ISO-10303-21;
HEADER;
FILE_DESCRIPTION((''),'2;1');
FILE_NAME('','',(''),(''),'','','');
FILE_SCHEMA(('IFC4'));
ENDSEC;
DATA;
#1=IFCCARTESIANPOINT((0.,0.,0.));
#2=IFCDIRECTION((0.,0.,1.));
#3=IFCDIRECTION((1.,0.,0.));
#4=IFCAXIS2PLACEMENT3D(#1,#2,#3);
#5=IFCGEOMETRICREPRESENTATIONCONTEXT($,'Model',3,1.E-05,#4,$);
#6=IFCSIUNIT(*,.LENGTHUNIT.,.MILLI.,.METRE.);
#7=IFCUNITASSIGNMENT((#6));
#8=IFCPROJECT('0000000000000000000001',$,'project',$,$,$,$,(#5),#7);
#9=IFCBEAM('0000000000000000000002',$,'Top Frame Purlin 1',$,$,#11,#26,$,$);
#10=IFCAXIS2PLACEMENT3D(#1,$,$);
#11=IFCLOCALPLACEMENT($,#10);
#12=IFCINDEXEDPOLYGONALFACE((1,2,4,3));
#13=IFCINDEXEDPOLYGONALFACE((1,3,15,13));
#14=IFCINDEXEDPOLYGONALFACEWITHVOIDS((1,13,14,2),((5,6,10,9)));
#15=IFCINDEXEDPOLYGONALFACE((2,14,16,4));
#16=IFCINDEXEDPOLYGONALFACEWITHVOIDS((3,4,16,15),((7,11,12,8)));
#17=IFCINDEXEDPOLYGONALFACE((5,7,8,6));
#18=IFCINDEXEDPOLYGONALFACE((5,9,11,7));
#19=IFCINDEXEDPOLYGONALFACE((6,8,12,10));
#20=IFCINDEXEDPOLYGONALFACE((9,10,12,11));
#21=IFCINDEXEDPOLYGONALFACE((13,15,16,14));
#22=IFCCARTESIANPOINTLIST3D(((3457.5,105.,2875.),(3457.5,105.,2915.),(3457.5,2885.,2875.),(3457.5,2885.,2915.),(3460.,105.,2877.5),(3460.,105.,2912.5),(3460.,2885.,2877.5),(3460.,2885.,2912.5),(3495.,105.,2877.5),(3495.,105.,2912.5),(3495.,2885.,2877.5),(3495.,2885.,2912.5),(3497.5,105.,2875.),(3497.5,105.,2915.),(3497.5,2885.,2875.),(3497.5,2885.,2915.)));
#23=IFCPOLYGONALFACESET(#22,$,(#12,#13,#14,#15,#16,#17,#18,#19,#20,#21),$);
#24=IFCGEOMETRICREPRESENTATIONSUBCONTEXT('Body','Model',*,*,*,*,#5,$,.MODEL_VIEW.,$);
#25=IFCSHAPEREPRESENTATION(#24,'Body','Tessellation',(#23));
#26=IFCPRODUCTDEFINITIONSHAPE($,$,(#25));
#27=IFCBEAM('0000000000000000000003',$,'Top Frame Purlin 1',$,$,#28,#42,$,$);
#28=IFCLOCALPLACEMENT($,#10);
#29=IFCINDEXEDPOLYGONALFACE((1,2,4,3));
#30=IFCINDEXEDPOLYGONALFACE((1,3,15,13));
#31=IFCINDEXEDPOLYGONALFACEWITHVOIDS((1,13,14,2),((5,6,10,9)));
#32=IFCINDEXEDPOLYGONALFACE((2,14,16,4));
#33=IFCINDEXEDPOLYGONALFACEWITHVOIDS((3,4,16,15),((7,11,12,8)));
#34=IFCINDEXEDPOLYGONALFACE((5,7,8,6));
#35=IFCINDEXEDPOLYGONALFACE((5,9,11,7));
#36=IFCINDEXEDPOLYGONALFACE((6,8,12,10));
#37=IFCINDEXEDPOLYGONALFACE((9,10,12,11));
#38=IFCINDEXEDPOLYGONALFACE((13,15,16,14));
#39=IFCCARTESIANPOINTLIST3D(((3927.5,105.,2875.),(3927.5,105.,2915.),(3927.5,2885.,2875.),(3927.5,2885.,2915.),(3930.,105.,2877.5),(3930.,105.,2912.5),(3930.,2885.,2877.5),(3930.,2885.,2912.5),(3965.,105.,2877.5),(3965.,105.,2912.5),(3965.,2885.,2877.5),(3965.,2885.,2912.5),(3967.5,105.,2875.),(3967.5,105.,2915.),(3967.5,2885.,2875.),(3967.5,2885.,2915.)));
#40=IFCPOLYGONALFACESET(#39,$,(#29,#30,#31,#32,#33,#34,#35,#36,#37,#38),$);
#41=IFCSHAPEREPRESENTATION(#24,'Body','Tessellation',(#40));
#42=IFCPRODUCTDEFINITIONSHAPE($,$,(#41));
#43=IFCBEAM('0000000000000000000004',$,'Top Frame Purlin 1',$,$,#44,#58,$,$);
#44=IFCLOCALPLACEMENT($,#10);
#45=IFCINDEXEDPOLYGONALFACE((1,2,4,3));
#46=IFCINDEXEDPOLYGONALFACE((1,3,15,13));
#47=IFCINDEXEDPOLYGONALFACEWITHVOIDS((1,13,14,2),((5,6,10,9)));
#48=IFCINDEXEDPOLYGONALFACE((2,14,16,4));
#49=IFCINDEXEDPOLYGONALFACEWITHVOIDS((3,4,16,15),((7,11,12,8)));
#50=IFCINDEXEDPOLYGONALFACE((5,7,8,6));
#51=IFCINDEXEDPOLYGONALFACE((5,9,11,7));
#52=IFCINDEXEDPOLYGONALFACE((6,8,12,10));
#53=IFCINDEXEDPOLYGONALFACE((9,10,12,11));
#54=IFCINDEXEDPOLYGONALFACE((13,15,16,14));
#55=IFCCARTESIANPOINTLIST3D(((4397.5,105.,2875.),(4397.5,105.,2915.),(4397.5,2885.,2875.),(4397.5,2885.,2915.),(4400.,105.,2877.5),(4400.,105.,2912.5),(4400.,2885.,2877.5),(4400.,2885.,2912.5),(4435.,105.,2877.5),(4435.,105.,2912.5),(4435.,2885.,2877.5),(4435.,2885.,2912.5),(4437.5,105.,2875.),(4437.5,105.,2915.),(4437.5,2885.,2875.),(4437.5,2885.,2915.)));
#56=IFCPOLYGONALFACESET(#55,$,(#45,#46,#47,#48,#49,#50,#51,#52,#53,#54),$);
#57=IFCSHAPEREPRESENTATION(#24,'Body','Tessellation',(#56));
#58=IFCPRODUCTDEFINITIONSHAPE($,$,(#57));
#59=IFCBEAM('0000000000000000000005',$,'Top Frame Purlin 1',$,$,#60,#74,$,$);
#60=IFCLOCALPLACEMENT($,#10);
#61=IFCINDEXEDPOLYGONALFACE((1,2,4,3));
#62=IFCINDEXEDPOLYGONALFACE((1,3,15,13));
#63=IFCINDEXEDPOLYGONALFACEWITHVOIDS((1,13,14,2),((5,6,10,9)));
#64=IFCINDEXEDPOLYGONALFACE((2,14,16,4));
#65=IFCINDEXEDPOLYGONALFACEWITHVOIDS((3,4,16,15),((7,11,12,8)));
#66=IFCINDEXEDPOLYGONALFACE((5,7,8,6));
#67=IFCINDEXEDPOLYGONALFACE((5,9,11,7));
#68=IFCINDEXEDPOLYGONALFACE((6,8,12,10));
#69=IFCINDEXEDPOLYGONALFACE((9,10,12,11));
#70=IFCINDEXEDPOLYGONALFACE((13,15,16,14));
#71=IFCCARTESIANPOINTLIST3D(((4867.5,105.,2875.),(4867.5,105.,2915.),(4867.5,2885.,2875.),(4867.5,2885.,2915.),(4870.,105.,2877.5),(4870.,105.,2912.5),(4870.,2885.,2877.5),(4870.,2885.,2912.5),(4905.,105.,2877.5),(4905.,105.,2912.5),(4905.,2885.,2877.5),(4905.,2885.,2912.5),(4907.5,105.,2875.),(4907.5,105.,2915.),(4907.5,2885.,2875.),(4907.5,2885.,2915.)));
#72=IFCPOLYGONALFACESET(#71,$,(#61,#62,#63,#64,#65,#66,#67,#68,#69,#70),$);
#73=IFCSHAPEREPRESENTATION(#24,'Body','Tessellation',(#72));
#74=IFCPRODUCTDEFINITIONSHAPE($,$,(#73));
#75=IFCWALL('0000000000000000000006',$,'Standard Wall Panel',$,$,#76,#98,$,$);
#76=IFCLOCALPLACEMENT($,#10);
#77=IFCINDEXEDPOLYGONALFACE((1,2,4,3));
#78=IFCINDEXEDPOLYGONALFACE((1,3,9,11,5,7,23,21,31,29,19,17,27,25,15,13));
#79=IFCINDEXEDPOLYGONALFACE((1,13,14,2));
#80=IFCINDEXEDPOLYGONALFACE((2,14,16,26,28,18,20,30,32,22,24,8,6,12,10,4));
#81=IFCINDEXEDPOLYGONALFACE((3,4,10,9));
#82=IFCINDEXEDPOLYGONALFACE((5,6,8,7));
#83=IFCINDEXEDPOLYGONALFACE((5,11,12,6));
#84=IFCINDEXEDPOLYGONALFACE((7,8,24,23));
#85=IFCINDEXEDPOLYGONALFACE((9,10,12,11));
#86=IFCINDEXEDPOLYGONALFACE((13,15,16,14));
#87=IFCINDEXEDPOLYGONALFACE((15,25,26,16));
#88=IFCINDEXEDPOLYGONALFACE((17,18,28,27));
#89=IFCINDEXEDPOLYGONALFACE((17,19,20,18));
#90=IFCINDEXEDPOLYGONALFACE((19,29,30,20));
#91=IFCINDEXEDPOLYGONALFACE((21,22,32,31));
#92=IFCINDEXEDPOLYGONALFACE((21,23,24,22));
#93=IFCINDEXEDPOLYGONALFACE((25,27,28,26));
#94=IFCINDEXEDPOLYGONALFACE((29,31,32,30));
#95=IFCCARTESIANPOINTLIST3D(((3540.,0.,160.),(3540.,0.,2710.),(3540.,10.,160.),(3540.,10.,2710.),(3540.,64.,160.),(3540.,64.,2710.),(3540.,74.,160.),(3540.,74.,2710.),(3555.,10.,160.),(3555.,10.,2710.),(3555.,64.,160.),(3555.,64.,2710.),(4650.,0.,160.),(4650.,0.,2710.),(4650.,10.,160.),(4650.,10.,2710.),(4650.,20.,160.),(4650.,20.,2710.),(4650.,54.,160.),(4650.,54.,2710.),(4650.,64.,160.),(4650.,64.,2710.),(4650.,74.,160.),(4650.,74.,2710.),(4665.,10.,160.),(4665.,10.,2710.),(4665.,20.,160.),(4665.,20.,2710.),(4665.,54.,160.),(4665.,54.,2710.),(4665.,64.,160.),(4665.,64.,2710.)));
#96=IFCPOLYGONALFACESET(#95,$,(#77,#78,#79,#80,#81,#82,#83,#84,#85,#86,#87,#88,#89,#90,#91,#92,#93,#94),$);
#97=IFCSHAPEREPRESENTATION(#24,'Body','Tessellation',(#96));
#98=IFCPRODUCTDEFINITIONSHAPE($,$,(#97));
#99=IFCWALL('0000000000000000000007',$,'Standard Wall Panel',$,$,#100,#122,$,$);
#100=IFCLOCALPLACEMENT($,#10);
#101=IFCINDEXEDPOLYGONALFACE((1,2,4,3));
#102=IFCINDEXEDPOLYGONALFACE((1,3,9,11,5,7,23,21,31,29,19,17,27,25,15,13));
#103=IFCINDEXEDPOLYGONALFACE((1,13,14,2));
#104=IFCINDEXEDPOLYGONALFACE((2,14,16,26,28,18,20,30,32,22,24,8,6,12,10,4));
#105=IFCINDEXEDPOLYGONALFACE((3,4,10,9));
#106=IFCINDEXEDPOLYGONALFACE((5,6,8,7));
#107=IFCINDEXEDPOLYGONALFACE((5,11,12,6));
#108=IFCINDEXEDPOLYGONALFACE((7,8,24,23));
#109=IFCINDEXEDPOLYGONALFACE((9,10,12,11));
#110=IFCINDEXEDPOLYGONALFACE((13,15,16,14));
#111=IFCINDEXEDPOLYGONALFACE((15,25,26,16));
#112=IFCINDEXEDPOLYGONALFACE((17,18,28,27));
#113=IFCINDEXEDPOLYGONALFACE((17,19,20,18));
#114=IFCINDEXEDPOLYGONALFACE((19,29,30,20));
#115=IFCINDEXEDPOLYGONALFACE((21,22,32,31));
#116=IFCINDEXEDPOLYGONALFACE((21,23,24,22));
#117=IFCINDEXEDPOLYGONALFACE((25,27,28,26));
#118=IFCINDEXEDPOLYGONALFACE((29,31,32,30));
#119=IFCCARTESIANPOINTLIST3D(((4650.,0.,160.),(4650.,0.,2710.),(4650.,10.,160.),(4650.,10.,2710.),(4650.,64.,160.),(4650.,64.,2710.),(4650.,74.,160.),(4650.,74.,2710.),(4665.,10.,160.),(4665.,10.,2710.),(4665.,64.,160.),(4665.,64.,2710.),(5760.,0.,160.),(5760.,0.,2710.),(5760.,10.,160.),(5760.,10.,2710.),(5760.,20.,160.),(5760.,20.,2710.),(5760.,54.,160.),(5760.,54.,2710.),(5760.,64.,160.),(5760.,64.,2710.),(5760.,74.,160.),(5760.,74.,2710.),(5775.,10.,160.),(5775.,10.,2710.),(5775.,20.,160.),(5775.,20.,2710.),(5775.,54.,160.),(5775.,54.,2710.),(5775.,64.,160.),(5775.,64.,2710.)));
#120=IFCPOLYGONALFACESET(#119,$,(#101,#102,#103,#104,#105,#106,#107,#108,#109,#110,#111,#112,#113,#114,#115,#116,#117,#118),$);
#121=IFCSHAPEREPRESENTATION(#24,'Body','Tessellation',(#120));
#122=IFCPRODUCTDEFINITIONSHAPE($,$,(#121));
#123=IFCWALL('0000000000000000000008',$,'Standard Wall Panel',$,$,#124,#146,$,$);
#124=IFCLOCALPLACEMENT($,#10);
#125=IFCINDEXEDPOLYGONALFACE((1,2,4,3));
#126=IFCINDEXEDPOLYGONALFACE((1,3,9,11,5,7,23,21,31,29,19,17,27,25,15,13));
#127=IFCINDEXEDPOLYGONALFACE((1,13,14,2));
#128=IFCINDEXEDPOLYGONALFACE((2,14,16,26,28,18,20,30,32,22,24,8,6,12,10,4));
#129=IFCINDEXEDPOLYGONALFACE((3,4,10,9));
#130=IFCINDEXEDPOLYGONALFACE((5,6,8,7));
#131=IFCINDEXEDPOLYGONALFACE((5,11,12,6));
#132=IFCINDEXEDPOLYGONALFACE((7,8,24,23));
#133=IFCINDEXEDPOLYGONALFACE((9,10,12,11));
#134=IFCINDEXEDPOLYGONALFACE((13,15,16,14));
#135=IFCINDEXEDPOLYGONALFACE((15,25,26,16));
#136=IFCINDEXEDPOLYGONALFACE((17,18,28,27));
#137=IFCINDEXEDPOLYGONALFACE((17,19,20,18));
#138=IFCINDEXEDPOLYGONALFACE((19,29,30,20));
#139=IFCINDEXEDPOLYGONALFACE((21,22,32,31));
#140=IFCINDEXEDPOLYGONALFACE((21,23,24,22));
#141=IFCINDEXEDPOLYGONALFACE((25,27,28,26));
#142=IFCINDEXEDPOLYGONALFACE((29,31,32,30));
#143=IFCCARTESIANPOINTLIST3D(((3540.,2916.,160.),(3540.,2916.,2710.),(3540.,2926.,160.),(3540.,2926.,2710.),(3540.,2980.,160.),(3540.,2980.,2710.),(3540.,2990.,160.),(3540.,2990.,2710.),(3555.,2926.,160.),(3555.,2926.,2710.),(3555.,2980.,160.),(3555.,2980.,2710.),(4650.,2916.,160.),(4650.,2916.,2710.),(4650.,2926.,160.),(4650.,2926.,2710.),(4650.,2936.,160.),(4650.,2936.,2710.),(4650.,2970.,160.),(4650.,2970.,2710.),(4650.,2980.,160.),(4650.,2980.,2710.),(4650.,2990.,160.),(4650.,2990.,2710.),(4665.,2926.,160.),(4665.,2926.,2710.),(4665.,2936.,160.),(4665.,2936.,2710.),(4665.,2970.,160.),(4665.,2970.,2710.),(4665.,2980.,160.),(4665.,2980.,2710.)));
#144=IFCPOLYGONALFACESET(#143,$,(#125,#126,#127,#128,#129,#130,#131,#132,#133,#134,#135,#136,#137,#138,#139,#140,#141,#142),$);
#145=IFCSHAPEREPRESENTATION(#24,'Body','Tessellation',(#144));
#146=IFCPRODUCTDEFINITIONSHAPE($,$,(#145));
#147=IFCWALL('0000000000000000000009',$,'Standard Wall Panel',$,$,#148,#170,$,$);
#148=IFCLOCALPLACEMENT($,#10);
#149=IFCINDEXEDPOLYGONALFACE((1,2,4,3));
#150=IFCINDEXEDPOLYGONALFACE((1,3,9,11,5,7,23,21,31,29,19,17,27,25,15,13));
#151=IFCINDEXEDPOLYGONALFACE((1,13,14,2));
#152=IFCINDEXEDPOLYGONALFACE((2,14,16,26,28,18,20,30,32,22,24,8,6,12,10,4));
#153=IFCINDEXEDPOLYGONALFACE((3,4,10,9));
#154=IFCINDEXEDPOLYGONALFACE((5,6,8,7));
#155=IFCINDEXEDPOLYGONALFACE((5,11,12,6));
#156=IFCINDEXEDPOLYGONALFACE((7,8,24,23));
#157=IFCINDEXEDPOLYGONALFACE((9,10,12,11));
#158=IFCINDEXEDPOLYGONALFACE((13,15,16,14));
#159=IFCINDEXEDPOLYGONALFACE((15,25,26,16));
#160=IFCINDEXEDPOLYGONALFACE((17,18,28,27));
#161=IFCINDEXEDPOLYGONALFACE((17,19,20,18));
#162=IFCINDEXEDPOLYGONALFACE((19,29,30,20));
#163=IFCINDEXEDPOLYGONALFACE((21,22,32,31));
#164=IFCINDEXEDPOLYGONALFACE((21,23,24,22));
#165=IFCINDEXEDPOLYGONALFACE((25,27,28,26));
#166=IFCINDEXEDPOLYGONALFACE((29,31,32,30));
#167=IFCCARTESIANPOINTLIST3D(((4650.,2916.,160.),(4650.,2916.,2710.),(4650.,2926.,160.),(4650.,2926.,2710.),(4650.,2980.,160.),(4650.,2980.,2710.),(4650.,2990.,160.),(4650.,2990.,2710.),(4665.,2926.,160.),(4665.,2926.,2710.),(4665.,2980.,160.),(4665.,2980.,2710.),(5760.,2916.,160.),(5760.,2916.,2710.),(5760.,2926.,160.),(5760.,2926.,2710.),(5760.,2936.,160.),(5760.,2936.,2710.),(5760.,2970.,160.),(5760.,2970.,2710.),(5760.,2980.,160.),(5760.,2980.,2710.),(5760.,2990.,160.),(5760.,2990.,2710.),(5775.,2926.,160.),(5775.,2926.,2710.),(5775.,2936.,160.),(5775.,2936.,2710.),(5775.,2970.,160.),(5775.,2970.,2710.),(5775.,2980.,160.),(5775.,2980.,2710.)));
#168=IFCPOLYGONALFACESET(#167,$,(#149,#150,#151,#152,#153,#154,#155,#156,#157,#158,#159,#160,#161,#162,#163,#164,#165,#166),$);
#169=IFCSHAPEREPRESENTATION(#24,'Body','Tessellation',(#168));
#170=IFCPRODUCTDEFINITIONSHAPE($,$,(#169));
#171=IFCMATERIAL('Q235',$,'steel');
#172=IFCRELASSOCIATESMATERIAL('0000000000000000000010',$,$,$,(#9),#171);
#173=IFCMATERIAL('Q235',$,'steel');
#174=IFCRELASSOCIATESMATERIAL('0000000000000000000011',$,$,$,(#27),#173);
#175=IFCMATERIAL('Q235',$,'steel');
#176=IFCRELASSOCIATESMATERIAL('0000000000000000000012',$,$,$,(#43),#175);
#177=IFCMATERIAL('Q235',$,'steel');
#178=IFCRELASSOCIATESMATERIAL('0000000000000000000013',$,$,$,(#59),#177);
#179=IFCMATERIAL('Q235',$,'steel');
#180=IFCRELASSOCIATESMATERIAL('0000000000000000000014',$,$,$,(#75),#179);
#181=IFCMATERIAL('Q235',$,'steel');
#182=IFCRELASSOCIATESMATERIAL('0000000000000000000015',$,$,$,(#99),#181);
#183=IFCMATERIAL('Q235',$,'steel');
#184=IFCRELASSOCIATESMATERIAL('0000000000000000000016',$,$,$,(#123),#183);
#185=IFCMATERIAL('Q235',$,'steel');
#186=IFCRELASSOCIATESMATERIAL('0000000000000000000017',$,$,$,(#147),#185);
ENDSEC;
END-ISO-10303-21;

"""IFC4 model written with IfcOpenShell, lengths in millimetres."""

from ifc_helpers import new_model, si_unit, frame, origin_with_axes, place, context, subcontext, project, line, indexed_curve, outline, extrude, material, element, save


model = new_model("IFC4")

# Units and contexts
model_context = context("Model", 3, precision=1e-05, world=origin_with_axes())
body_context = subcontext(model_context, "Body", "Model", "MODEL_VIEW")
ifc_project = project(units=[si_unit("LENGTHUNIT", "METRE", prefix="MILLI")], contexts=[model_context])

# Beams, openings
ifc_material_1 = material(Name="Q235", Category="steel")
beam_1_placement = place(None, frame((3457.5, 105.0, 2875.0), z_axis=(0.0, 1.0, 0.0), x_axis=(1.0, 0.0, 0.0)))
beam_1 = element("IfcBeam", 1, at=beam_1_placement, material=ifc_material_1, Name="Top Frame Purlin 1", context=body_context, shape_type="SweptSolid", body=[
    extrude(outline(indexed_curve([(0.0, 0.0), (0.0, -40.0), (40.0, -40.0), (40.0, 0.0), (0.0, 0.0)], segments=[line(1, 2, 3, 4, 5, 1)])), origin_with_axes(), (0.0, 0.0, 1.0), 2780.0),
])
opening_1_placement = place(beam_1_placement, frame((2.5, -2.5, 0.0), z_axis=(0.0, 0.0, 1.0), x_axis=(1.0, 0.0, 0.0)))
element("IfcOpeningElement", 2, at=opening_1_placement, cuts=beam_1, context=body_context, shape_type="SweptSolid", body=[
    extrude(outline(indexed_curve([(0.0, 0.0), (0.0, -35.0), (35.0, -35.0), (35.0, 0.0)], segments=[line(1, 2, 3, 4, 1)])), origin_with_axes(), (0.0, 0.0, 1.0), 2780.0),
])
ifc_material_2 = material(Name="Q235", Category="steel")
beam_2_placement = place(None, frame((3927.5, 105.0, 2875.0), z_axis=(0.0, 1.0, 0.0), x_axis=(1.0, 0.0, 0.0)))
beam_2 = element("IfcBeam", 3, at=beam_2_placement, material=ifc_material_2, Name="Top Frame Purlin 1", context=body_context, shape_type="SweptSolid", body=[
    extrude(outline(indexed_curve([(0.0, 0.0), (0.0, -40.0), (40.0, -40.0), (40.0, 0.0), (0.0, 0.0)], segments=[line(1, 2, 3, 4, 5, 1)])), origin_with_axes(), (0.0, 0.0, 1.0), 2780.0),
])
opening_2_placement = place(beam_2_placement, frame((2.5, -2.5, 0.0), z_axis=(0.0, 0.0, 1.0), x_axis=(1.0, 0.0, 0.0)))
element("IfcOpeningElement", 4, at=opening_2_placement, cuts=beam_2, context=body_context, shape_type="SweptSolid", body=[
    extrude(outline(indexed_curve([(0.0, 0.0), (0.0, -35.0), (35.0, -35.0), (35.0, 0.0)], segments=[line(1, 2, 3, 4, 1)])), origin_with_axes(), (0.0, 0.0, 1.0), 2780.0),
])
ifc_material_3 = material(Name="Q235", Category="steel")
beam_3_placement = place(None, frame((4397.5, 105.0, 2875.0), z_axis=(0.0, 1.0, 0.0), x_axis=(1.0, 0.0, 0.0)))
beam_3 = element("IfcBeam", 5, at=beam_3_placement, material=ifc_material_3, Name="Top Frame Purlin 1", context=body_context, shape_type="SweptSolid", body=[
    extrude(outline(indexed_curve([(0.0, 0.0), (0.0, -40.0), (40.0, -40.0), (40.0, 0.0), (0.0, 0.0)], segments=[line(1, 2, 3, 4, 5, 1)])), origin_with_axes(), (0.0, 0.0, 1.0), 2780.0),
])
opening_3_placement = place(beam_3_placement, frame((2.5, -2.5, 0.0), z_axis=(0.0, 0.0, 1.0), x_axis=(1.0, 0.0, 0.0)))
element("IfcOpeningElement", 6, at=opening_3_placement, cuts=beam_3, context=body_context, shape_type="SweptSolid", body=[
    extrude(outline(indexed_curve([(0.0, 0.0), (0.0, -35.0), (35.0, -35.0), (35.0, 0.0)], segments=[line(1, 2, 3, 4, 1)])), origin_with_axes(), (0.0, 0.0, 1.0), 2780.0),
])
ifc_material_4 = material(Name="Q235", Category="steel")
beam_4_placement = place(None, frame((4867.5, 105.0, 2875.0), z_axis=(0.0, 1.0, 0.0), x_axis=(1.0, 0.0, 0.0)))
beam_4 = element("IfcBeam", 7, at=beam_4_placement, material=ifc_material_4, Name="Top Frame Purlin 1", context=body_context, shape_type="SweptSolid", body=[
    extrude(outline(indexed_curve([(0.0, 0.0), (0.0, -40.0), (40.0, -40.0), (40.0, 0.0), (0.0, 0.0)], segments=[line(1, 2, 3, 4, 5, 1)])), origin_with_axes(), (0.0, 0.0, 1.0), 2780.0),
])
opening_4_placement = place(beam_4_placement, frame((2.5, -2.5, 0.0), z_axis=(0.0, 0.0, 1.0), x_axis=(1.0, 0.0, 0.0)))
element("IfcOpeningElement", 8, at=opening_4_placement, cuts=beam_4, context=body_context, shape_type="SweptSolid", body=[
    extrude(outline(indexed_curve([(0.0, 0.0), (0.0, -35.0), (35.0, -35.0), (35.0, 0.0)], segments=[line(1, 2, 3, 4, 1)])), origin_with_axes(), (0.0, 0.0, 1.0), 2780.0),
])

# Walls
ifc_material_5 = material(Name="Q235", Category="steel")
wall_1_placement = place(None, frame((3540.0, 0.0, 160.0), z_axis=(0.0, 0.0, 1.0), x_axis=(1.0, 0.0, 0.0)))
element("IfcWall", 9, at=wall_1_placement, material=ifc_material_5, Name="Standard Wall Panel", context=body_context, shape_type="SweptSolid", body=[
    extrude(outline(indexed_curve([(0.0, 0.0), (0.0, 10.0), (15.0, 10.0), (15.0, 64.0), (0.0, 64.0), (0.0, 74.0), (1110.0, 74.0), (1110.0, 64.0), (1125.0, 64.0), (1125.0, 54.0), (1125.0, 54.0), (1110.0, 54.0), (1110.0, 20.0), (1125.0, 20.0), (1125.0, 10.0), (1110.0, 10.0), (1110.0, 0.0), (0.0, 0.0)], segments=[line(1, 2, 3, 4, 5, 6, 7, 8, 9, 10, 11, 12, 13, 14, 15, 16, 17, 18, 1)])), origin_with_axes(), (0.0, 0.0, 1.0), 2550.0),
])
ifc_material_6 = material(Name="Q235", Category="steel")
wall_2_placement = place(None, frame((4650.0, 0.0, 160.0), z_axis=(0.0, 0.0, 1.0), x_axis=(1.0, 0.0, 0.0)))
element("IfcWall", 10, at=wall_2_placement, material=ifc_material_6, Name="Standard Wall Panel", context=body_context, shape_type="SweptSolid", body=[
    extrude(outline(indexed_curve([(0.0, 0.0), (0.0, 10.0), (15.0, 10.0), (15.0, 64.0), (0.0, 64.0), (0.0, 74.0), (1110.0, 74.0), (1110.0, 64.0), (1125.0, 64.0), (1125.0, 54.0), (1125.0, 54.0), (1110.0, 54.0), (1110.0, 20.0), (1125.0, 20.0), (1125.0, 10.0), (1110.0, 10.0), (1110.0, 0.0), (0.0, 0.0)], segments=[line(1, 2, 3, 4, 5, 6, 7, 8, 9, 10, 11, 12, 13, 14, 15, 16, 17, 18, 1)])), origin_with_axes(), (0.0, 0.0, 1.0), 2550.0),
])
ifc_material_7 = material(Name="Q235", Category="steel")
wall_3_placement = place(None, frame((3540.0, 2916.0, 160.0), z_axis=(0.0, 0.0, 1.0), x_axis=(1.0, 0.0, 0.0)))
element("IfcWall", 11, at=wall_3_placement, material=ifc_material_7, Name="Standard Wall Panel", context=body_context, shape_type="SweptSolid", body=[
    extrude(outline(indexed_curve([(0.0, 0.0), (0.0, 10.0), (15.0, 10.0), (15.0, 64.0), (0.0, 64.0), (0.0, 74.0), (1110.0, 74.0), (1110.0, 64.0), (1125.0, 64.0), (1125.0, 54.0), (1125.0, 54.0), (1110.0, 54.0), (1110.0, 20.0), (1125.0, 20.0), (1125.0, 10.0), (1110.0, 10.0), (1110.0, 0.0), (0.0, 0.0)], segments=[line(1, 2, 3, 4, 5, 6, 7, 8, 9, 10, 11, 12, 13, 14, 15, 16, 17, 18, 1)])), origin_with_axes(), (0.0, 0.0, 1.0), 2550.0),
])
ifc_material_8 = material(Name="Q235", Category="steel")
wall_4_placement = place(None, frame((4650.0, 2916.0, 160.0), z_axis=(0.0, 0.0, 1.0), x_axis=(1.0, 0.0, 0.0)))
element("IfcWall", 12, at=wall_4_placement, material=ifc_material_8, Name="Standard Wall Panel", context=body_context, shape_type="SweptSolid", body=[
    extrude(outline(indexed_curve([(0.0, 0.0), (0.0, 10.0), (15.0, 10.0), (15.0, 64.0), (0.0, 64.0), (0.0, 74.0), (1110.0, 74.0), (1110.0, 64.0), (1125.0, 64.0), (1125.0, 54.0), (1125.0, 54.0), (1110.0, 54.0), (1110.0, 20.0), (1125.0, 20.0), (1125.0, 10.0), (1110.0, 10.0), (1110.0, 0.0), (0.0, 0.0)], segments=[line(1, 2, 3, 4, 5, 6, 7, 8, 9, 10, 11, 12, 13, 14, 15, 16, 17, 18, 1)])), origin_with_axes(), (0.0, 0.0, 1.0), 2550.0),
])

save(model, "model.ifc")
